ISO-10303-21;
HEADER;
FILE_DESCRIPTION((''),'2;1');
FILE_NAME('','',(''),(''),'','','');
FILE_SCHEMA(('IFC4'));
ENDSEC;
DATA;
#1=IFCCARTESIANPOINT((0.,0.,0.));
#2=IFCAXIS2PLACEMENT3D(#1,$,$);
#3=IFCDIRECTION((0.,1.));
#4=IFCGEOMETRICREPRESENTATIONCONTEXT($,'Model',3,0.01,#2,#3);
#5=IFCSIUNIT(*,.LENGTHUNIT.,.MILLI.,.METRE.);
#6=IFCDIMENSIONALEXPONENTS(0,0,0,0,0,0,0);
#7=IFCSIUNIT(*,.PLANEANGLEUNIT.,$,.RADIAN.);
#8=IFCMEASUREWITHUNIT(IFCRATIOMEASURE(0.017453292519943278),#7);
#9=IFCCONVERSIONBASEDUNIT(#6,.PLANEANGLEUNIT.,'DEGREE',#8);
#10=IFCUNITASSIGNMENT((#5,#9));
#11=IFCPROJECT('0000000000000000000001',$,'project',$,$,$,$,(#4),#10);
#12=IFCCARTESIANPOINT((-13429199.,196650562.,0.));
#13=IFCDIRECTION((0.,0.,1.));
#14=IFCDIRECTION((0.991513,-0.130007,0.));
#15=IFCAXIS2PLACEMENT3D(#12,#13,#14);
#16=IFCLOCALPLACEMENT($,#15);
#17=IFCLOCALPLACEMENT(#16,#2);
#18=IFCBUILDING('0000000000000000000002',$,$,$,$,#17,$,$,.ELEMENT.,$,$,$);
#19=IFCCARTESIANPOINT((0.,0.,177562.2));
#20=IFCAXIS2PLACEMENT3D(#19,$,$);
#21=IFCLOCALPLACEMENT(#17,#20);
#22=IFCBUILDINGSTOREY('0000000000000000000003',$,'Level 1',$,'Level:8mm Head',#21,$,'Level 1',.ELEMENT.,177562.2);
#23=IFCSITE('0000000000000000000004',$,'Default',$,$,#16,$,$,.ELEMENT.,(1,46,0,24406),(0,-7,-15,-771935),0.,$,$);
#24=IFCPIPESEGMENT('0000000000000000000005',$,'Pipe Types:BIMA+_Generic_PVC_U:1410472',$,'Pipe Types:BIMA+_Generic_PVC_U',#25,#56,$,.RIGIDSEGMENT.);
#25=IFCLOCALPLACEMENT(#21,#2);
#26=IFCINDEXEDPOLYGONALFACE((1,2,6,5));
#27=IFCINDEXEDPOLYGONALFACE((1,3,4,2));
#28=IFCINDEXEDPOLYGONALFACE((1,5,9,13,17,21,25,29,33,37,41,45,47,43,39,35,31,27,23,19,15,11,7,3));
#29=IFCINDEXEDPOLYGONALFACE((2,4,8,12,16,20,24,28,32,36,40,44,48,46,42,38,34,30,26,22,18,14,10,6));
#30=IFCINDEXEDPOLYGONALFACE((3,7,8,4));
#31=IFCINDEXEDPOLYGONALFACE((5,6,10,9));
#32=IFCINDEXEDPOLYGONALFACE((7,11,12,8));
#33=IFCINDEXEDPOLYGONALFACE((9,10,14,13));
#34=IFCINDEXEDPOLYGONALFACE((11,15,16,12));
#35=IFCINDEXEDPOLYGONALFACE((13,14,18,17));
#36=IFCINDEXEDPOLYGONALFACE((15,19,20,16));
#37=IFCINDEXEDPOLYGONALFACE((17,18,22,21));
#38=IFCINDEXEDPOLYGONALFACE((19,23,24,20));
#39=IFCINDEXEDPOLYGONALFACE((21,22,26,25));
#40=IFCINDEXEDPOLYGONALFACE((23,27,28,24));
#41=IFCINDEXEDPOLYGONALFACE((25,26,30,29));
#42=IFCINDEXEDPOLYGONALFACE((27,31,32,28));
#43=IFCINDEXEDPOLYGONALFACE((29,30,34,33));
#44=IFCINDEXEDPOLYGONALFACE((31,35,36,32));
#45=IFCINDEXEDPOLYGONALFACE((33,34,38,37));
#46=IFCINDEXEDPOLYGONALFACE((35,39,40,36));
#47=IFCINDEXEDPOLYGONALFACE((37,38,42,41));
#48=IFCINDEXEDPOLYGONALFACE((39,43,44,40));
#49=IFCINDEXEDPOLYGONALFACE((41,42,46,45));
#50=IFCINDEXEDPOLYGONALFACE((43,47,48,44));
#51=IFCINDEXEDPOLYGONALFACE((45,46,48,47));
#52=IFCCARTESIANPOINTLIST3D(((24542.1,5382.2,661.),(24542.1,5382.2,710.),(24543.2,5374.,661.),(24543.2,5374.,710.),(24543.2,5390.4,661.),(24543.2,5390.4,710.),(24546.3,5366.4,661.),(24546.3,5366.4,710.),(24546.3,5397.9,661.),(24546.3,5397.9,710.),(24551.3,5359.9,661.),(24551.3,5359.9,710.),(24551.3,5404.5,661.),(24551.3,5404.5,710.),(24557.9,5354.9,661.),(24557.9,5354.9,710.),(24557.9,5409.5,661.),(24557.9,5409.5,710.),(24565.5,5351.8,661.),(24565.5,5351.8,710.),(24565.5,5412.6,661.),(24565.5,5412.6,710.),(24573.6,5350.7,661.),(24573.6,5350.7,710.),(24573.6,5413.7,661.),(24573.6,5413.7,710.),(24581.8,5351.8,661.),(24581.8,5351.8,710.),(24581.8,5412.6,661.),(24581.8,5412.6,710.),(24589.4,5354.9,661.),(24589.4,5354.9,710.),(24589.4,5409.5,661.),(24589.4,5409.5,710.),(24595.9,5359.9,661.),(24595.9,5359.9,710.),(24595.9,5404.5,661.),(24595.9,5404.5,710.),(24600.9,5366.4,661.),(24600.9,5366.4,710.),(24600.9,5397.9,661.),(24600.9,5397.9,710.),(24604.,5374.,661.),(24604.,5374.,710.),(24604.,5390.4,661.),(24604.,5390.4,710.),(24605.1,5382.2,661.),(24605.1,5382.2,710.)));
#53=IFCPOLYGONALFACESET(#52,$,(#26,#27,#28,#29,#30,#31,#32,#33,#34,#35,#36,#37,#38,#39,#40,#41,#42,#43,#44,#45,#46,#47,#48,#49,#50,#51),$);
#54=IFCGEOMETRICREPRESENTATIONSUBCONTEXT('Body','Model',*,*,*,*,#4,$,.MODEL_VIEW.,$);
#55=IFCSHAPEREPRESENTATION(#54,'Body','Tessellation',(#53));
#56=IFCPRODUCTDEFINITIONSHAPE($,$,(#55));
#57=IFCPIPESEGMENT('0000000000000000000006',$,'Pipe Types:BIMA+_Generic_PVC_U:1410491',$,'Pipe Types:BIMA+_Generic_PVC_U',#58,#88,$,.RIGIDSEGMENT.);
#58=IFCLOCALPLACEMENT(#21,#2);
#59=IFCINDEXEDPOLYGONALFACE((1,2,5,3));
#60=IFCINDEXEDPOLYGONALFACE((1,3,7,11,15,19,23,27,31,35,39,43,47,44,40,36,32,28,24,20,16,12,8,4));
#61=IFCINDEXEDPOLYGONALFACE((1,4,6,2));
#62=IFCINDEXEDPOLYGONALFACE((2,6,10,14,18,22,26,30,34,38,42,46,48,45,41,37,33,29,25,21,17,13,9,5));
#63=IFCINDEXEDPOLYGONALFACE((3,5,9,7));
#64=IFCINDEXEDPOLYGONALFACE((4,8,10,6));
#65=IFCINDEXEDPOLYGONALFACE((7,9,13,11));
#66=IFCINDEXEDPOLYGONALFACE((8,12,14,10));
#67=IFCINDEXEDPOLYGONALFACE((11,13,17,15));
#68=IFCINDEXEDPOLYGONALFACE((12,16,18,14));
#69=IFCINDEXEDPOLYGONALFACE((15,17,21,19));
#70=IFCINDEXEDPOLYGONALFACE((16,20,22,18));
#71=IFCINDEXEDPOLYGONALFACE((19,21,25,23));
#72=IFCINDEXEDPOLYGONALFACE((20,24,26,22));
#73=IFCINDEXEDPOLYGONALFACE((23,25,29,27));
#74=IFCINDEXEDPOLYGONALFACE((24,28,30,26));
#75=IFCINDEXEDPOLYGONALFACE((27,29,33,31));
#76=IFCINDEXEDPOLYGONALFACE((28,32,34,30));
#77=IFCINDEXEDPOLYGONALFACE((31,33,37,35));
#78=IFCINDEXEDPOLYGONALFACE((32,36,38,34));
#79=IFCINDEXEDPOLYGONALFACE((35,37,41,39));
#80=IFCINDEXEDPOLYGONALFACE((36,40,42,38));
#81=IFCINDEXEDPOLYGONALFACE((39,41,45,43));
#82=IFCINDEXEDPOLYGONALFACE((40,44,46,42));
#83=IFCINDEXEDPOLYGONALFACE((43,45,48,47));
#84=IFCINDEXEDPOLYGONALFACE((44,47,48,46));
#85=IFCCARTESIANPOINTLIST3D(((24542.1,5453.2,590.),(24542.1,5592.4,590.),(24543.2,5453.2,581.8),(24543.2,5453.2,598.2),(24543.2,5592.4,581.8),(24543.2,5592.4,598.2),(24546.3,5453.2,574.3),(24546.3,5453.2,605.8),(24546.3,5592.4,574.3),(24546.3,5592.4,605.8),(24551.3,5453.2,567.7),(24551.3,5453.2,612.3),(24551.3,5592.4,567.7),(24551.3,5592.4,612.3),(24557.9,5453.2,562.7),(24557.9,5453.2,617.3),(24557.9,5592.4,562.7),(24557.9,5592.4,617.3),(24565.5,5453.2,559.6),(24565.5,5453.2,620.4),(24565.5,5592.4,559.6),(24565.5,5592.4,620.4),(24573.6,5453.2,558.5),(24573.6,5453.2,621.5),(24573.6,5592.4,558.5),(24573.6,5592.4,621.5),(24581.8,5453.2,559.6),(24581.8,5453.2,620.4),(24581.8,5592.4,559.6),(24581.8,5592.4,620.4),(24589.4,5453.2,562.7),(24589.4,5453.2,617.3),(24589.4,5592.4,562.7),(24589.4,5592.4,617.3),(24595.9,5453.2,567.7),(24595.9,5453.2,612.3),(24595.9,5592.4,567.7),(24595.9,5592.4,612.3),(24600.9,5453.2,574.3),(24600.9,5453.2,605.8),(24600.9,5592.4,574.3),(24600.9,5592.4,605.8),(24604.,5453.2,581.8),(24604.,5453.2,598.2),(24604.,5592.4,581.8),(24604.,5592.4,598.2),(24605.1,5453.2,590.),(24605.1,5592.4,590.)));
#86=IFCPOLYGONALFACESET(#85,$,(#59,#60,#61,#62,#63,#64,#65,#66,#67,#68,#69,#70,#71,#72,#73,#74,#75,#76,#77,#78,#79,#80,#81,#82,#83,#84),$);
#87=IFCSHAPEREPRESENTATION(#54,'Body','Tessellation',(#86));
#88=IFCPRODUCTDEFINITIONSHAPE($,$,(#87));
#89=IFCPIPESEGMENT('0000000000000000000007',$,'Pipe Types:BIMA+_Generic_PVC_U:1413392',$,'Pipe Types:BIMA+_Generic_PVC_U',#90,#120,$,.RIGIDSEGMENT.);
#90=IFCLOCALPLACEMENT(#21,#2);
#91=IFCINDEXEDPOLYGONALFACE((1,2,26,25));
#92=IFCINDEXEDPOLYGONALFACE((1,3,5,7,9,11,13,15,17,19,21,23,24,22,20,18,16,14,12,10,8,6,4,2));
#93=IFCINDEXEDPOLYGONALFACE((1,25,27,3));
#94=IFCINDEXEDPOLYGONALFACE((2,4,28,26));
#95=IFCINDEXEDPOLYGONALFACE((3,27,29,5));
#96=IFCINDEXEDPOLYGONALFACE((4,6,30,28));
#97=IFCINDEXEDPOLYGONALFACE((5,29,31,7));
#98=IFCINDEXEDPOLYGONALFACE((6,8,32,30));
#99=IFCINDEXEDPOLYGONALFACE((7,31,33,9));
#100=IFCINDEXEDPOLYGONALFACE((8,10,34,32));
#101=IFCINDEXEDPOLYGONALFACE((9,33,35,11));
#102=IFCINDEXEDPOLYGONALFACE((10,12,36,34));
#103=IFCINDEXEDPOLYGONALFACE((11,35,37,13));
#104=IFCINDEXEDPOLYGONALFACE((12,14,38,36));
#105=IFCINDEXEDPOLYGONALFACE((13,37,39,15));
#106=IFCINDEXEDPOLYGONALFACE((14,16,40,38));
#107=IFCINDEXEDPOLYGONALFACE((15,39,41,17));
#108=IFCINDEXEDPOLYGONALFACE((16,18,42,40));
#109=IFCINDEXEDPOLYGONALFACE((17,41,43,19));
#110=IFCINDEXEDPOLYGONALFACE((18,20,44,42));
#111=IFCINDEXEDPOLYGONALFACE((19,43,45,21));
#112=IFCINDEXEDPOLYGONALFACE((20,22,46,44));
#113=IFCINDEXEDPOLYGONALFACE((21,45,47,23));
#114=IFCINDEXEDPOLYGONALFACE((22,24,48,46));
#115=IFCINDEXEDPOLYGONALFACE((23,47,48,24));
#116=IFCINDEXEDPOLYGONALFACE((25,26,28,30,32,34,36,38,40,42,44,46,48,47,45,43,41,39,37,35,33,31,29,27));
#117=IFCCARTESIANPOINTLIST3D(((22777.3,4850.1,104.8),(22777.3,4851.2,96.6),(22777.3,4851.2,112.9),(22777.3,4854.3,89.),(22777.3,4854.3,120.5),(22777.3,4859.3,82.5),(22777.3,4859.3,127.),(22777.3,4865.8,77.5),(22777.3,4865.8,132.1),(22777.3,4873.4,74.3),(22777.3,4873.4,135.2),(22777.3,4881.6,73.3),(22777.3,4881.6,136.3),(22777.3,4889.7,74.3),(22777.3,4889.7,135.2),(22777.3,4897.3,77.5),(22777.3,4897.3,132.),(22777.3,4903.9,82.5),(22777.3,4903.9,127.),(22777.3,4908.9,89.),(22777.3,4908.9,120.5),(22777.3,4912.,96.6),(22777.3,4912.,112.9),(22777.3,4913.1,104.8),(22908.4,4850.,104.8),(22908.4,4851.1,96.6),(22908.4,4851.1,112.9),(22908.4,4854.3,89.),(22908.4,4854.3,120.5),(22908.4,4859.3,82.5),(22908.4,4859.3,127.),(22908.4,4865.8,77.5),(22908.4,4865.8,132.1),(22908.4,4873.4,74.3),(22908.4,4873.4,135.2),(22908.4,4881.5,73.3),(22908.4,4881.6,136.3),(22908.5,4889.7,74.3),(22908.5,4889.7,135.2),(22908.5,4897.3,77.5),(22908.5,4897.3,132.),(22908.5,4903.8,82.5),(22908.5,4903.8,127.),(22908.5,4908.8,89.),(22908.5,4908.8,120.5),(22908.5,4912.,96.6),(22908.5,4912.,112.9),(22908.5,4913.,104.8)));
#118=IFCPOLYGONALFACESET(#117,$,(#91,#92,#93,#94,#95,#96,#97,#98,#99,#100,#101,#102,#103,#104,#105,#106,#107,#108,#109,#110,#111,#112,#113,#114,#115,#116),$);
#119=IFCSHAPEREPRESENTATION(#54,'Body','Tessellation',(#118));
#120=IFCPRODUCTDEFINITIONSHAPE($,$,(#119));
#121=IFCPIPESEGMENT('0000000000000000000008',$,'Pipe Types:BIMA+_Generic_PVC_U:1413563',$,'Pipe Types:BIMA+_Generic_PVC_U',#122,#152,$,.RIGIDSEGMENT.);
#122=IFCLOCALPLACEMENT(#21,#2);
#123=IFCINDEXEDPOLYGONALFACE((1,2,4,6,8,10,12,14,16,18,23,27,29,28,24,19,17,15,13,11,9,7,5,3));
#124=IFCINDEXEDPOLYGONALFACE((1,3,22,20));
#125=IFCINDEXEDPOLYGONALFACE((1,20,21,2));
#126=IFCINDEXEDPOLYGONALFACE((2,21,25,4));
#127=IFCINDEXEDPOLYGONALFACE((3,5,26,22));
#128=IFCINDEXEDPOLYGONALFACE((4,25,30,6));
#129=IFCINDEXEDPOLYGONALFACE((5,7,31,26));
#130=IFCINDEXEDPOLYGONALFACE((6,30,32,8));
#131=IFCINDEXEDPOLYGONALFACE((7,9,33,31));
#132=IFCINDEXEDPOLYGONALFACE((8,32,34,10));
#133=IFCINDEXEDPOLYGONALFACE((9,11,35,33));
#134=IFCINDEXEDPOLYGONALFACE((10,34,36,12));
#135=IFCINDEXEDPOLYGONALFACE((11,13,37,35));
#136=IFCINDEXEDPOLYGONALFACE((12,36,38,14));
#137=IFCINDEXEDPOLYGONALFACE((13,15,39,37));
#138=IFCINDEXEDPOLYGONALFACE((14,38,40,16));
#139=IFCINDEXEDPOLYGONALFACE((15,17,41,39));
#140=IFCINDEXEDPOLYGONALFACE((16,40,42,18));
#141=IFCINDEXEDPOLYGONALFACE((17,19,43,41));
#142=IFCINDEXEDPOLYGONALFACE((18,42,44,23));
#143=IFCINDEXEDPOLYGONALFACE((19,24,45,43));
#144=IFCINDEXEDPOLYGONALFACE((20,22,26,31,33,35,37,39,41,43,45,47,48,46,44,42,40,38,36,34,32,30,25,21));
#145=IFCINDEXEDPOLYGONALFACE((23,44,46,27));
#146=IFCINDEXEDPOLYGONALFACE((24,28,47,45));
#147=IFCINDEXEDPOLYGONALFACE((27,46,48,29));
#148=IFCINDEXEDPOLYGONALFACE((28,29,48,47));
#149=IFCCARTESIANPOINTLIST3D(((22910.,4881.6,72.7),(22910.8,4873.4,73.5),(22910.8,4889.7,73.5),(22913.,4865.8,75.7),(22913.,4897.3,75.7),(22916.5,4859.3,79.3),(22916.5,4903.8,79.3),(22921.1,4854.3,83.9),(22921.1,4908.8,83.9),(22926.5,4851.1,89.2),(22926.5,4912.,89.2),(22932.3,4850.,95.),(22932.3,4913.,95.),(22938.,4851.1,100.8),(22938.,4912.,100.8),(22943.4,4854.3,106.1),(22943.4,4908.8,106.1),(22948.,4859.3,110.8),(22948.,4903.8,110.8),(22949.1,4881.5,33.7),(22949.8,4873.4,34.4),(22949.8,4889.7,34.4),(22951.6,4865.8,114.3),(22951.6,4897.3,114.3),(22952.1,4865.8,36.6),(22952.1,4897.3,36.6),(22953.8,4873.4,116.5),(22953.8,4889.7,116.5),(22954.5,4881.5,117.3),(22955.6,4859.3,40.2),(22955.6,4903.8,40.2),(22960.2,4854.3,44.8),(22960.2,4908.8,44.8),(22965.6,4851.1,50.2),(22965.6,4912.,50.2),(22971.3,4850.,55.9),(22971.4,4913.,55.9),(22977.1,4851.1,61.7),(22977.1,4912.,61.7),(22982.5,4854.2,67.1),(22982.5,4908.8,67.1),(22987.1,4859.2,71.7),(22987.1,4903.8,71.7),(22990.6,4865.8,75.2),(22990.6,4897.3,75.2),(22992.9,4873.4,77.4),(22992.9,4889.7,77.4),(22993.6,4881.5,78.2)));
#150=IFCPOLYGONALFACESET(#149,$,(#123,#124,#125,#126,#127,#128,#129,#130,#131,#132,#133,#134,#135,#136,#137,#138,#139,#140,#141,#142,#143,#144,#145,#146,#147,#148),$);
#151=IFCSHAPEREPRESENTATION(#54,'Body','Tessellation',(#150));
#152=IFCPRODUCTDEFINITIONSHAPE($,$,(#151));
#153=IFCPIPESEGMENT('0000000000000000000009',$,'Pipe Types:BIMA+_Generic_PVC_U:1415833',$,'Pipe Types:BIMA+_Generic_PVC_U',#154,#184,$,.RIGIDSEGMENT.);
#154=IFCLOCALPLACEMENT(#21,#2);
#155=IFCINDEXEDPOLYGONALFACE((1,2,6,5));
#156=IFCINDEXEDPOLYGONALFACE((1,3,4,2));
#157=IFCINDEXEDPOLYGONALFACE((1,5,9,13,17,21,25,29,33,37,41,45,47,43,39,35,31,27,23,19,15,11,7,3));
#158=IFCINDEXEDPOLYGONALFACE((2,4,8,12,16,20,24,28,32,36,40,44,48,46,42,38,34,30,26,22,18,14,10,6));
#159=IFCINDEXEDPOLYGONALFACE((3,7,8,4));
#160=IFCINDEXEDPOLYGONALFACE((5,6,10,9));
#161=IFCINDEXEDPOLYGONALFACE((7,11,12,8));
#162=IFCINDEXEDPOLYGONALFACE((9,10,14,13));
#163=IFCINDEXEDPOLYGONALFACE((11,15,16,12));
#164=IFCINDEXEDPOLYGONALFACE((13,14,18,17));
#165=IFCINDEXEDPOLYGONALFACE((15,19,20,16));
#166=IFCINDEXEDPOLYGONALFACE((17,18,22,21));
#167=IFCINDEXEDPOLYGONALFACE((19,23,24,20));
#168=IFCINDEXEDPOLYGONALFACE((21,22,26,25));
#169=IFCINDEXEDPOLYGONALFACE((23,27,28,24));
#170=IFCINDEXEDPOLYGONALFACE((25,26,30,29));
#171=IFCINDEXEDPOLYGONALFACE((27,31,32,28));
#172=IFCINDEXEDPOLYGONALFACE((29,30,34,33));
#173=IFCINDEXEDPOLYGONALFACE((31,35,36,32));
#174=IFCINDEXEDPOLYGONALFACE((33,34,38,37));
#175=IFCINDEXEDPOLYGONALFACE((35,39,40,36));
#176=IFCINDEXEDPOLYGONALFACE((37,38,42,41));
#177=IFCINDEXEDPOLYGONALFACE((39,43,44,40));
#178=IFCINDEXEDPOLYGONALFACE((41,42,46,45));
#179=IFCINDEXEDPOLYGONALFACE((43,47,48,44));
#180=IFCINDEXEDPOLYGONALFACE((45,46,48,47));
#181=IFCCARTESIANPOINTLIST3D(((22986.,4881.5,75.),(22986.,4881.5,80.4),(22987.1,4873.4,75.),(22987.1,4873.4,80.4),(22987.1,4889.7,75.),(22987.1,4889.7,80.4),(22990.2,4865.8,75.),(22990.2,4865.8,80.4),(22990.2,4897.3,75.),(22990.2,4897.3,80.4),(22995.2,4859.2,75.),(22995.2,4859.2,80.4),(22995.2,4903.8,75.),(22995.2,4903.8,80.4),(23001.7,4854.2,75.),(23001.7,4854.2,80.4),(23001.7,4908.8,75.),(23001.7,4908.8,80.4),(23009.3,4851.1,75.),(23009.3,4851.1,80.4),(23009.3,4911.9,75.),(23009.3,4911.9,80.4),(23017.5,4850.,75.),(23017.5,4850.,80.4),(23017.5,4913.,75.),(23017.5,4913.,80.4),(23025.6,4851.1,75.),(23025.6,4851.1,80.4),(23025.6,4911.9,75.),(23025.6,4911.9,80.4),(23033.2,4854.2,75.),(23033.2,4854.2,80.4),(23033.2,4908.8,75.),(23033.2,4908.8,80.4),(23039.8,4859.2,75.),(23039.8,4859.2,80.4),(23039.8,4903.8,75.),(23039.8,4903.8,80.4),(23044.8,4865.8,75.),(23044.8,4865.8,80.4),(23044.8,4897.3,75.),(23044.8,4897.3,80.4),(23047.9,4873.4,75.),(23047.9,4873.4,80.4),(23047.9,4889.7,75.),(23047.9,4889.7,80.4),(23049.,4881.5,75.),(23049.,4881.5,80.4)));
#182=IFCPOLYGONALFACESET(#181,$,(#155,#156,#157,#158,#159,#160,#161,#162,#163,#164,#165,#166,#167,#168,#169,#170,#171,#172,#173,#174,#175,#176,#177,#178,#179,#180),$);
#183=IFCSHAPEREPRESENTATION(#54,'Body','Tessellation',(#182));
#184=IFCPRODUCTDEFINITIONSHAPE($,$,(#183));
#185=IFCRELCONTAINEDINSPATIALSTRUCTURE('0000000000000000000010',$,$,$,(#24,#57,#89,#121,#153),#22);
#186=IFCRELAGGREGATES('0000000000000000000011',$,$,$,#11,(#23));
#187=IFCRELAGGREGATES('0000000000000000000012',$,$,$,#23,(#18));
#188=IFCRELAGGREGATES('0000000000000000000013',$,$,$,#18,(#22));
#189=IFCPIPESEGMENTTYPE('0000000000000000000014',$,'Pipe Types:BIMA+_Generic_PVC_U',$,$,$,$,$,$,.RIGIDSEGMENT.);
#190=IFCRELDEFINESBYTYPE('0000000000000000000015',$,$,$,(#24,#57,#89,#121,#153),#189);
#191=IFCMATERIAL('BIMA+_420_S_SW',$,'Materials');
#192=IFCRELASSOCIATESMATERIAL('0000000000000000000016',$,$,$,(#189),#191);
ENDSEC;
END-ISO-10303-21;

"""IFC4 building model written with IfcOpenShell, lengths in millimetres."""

from ifc_helpers import new_model, entity, si_unit, converted_unit, direction, frame, origin, place, context, subcontext, project, spatial, arc, indexed_curve, outline, extrude, material, type_object, element, save


model = new_model("IFC4")

# Units and contexts
model_context = context("Model", 3, precision=0.01, world=origin(), true_north=direction((0.0, 1.0)))
body_context = subcontext(model_context, "Body", "Model", "MODEL_VIEW")
ifc_project = project(units=[si_unit("LENGTHUNIT", "METRE", prefix="MILLI"), converted_unit("PLANEANGLEUNIT", "DEGREE", entity("IfcRatioMeasure", 0.017453292519943278), si_unit("PLANEANGLEUNIT", "RADIAN"), dimensions=[0, 0, 0, 0, 0, 0, 0])], contexts=[model_context])

# Site, building, storey
site_placement = place(None, frame((-13429199.0, 196650562.0, 0.0), z_axis=(0.0, 0.0, 1.0), x_axis=(0.991513, -0.130007, 0.0)))
site = spatial("IfcSite", under=ifc_project, at=site_placement, Name="Default", CompositionType="ELEMENT", RefLatitude=(1, 46, 0, 24406), RefLongitude=(0, -7, -15, -771935), RefElevation=0.0)
building_placement = place(site_placement, origin())
building = spatial("IfcBuilding", under=site, at=building_placement, CompositionType="ELEMENT")
storey_placement = place(building_placement, frame((0.0, 0.0, 177562.2)))
storey = spatial("IfcBuildingStorey", under=building, at=storey_placement, Name="Level 1", ObjectType="Level:8mm Head", LongName="Level 1", CompositionType="ELEMENT", Elevation=177562.2)

# Pipe segments
ifc_material_1 = material(Name="BIMA+_420_S_SW", Category="Materials")
pipe_segment_type_1 = type_object("IfcPipeSegmentType", Name="Pipe Types:BIMA+_Generic_PVC_U", PredefinedType="RIGIDSEGMENT", material=ifc_material_1)
pipe_segment_1_placement = place(storey_placement, frame((24540.5, 5349.1, 661.0)))
element("IfcPipeSegment", 1, at=pipe_segment_1_placement, inside=storey, type_object=pipe_segment_type_1, Name="Pipe Types:BIMA+_Generic_PVC_U:1410472", ObjectType="Pipe Types:BIMA+_Generic_PVC_U", PredefinedType="RIGIDSEGMENT", context=body_context, shape_type="SweptSolid", body=[
    extrude(outline(indexed_curve([(31.5, 0.0), (22.3, 22.3), (0.0, 31.5), (-22.3, 22.3), (-31.5, 0.0), (-22.3, -22.3), (0.0, -31.5), (22.3, -22.3)], segments=[arc(1, 2, 3), arc(3, 4, 5), arc(5, 6, 7), arc(7, 8, 1)], self_intersect=False)), frame((33.1, 33.1, 0.0)), (0.0, 0.0, 1.0), 49.0),
])
pipe_segment_2_placement = place(storey_placement, frame((24540.5, 5453.2, 556.9)))
element("IfcPipeSegment", 2, at=pipe_segment_2_placement, inside=storey, type_object=pipe_segment_type_1, Name="Pipe Types:BIMA+_Generic_PVC_U:1410491", ObjectType="Pipe Types:BIMA+_Generic_PVC_U", PredefinedType="RIGIDSEGMENT", context=body_context, shape_type="SweptSolid", body=[
    extrude(outline(indexed_curve([(31.5, 0.0), (22.3, 22.3), (0.0, 31.5), (-22.3, 22.3), (-31.5, 0.0), (-22.3, -22.3), (0.0, -31.5), (22.3, -22.3)], segments=[arc(1, 2, 3), arc(3, 4, 5), arc(5, 6, 7), arc(7, 8, 1)], self_intersect=False)), frame((33.1, 0.0, 33.1), z_axis=(0.0, 1.0, 0.0), x_axis=(1.0, 0.0, 0.0)), (0.0, 0.0, 1.0), 139.2),
])
pipe_segment_3_placement = place(storey_placement, frame((22777.3, 4848.5, 71.7)))
element("IfcPipeSegment", 3, at=pipe_segment_3_placement, inside=storey, type_object=pipe_segment_type_1, Name="Pipe Types:BIMA+_Generic_PVC_U:1413392", ObjectType="Pipe Types:BIMA+_Generic_PVC_U", PredefinedType="RIGIDSEGMENT", context=body_context, shape_type="SweptSolid", body=[
    extrude(outline(indexed_curve([(31.5, 0.0), (22.3, 22.3), (0.0, 31.5), (-22.3, 22.3), (-31.5, 0.0), (-22.3, -22.3), (0.0, -31.5), (22.3, -22.3)], segments=[arc(1, 2, 3), arc(3, 4, 5), arc(5, 6, 7), arc(7, 8, 1)], self_intersect=False)), frame((0.0, 33.1, 33.1), z_axis=(1.0, -0.000251, 0.0), x_axis=(-0.000251, -1.0, 0.000054)), (0.0, 0.0, 1.0), 131.1),
])
pipe_segment_4_placement = place(storey_placement, frame((22908.4, 4848.4, 118.9)))
element("IfcPipeSegment", 4, at=pipe_segment_4_placement, inside=storey, type_object=pipe_segment_type_1, Name="Pipe Types:BIMA+_Generic_PVC_U:1413563", ObjectType="Pipe Types:BIMA+_Generic_PVC_U", PredefinedType="RIGIDSEGMENT", context=body_context, shape_type="SweptSolid", body=[
    extrude(outline(indexed_curve([(31.5, 0.0), (22.3, 22.3), (0.0, 31.5), (-22.3, 22.3), (-31.5, 0.0), (-22.3, -22.3), (0.0, -31.5), (22.3, -22.3)], segments=[arc(1, 2, 3), arc(3, 4, 5), arc(5, 6, 7), arc(7, 8, 1)], self_intersect=False)), frame((23.9, 33.1, -23.9), z_axis=(0.707107, -0.000342, -0.707107), x_axis=(-0.000484, -1.0, 0.0)), (0.0, 0.0, 1.0), 55.3),
])
pipe_segment_5_placement = place(storey_placement, frame((22984.4, 4848.4, 75.0)))
element("IfcPipeSegment", 5, at=pipe_segment_5_placement, inside=storey, type_object=pipe_segment_type_1, Name="Pipe Types:BIMA+_Generic_PVC_U:1415833", ObjectType="Pipe Types:BIMA+_Generic_PVC_U", PredefinedType="RIGIDSEGMENT", context=body_context, shape_type="SweptSolid", body=[
    extrude(outline(indexed_curve([(31.5, 0.0), (22.3, 22.3), (0.0, 31.5), (-22.3, 22.3), (-31.5, 0.0), (-22.3, -22.3), (0.0, -31.5), (22.3, -22.3)], segments=[arc(1, 2, 3), arc(3, 4, 5), arc(5, 6, 7), arc(7, 8, 1)], self_intersect=False)), frame((33.1, 33.1, 0.0), z_axis=(0.0, 0.000033, 1.0), x_axis=(-1.0, 0.0, 0.0)), (0.0, 0.0, 1.0), 5.4),
])

save(model, "model.ifc")
